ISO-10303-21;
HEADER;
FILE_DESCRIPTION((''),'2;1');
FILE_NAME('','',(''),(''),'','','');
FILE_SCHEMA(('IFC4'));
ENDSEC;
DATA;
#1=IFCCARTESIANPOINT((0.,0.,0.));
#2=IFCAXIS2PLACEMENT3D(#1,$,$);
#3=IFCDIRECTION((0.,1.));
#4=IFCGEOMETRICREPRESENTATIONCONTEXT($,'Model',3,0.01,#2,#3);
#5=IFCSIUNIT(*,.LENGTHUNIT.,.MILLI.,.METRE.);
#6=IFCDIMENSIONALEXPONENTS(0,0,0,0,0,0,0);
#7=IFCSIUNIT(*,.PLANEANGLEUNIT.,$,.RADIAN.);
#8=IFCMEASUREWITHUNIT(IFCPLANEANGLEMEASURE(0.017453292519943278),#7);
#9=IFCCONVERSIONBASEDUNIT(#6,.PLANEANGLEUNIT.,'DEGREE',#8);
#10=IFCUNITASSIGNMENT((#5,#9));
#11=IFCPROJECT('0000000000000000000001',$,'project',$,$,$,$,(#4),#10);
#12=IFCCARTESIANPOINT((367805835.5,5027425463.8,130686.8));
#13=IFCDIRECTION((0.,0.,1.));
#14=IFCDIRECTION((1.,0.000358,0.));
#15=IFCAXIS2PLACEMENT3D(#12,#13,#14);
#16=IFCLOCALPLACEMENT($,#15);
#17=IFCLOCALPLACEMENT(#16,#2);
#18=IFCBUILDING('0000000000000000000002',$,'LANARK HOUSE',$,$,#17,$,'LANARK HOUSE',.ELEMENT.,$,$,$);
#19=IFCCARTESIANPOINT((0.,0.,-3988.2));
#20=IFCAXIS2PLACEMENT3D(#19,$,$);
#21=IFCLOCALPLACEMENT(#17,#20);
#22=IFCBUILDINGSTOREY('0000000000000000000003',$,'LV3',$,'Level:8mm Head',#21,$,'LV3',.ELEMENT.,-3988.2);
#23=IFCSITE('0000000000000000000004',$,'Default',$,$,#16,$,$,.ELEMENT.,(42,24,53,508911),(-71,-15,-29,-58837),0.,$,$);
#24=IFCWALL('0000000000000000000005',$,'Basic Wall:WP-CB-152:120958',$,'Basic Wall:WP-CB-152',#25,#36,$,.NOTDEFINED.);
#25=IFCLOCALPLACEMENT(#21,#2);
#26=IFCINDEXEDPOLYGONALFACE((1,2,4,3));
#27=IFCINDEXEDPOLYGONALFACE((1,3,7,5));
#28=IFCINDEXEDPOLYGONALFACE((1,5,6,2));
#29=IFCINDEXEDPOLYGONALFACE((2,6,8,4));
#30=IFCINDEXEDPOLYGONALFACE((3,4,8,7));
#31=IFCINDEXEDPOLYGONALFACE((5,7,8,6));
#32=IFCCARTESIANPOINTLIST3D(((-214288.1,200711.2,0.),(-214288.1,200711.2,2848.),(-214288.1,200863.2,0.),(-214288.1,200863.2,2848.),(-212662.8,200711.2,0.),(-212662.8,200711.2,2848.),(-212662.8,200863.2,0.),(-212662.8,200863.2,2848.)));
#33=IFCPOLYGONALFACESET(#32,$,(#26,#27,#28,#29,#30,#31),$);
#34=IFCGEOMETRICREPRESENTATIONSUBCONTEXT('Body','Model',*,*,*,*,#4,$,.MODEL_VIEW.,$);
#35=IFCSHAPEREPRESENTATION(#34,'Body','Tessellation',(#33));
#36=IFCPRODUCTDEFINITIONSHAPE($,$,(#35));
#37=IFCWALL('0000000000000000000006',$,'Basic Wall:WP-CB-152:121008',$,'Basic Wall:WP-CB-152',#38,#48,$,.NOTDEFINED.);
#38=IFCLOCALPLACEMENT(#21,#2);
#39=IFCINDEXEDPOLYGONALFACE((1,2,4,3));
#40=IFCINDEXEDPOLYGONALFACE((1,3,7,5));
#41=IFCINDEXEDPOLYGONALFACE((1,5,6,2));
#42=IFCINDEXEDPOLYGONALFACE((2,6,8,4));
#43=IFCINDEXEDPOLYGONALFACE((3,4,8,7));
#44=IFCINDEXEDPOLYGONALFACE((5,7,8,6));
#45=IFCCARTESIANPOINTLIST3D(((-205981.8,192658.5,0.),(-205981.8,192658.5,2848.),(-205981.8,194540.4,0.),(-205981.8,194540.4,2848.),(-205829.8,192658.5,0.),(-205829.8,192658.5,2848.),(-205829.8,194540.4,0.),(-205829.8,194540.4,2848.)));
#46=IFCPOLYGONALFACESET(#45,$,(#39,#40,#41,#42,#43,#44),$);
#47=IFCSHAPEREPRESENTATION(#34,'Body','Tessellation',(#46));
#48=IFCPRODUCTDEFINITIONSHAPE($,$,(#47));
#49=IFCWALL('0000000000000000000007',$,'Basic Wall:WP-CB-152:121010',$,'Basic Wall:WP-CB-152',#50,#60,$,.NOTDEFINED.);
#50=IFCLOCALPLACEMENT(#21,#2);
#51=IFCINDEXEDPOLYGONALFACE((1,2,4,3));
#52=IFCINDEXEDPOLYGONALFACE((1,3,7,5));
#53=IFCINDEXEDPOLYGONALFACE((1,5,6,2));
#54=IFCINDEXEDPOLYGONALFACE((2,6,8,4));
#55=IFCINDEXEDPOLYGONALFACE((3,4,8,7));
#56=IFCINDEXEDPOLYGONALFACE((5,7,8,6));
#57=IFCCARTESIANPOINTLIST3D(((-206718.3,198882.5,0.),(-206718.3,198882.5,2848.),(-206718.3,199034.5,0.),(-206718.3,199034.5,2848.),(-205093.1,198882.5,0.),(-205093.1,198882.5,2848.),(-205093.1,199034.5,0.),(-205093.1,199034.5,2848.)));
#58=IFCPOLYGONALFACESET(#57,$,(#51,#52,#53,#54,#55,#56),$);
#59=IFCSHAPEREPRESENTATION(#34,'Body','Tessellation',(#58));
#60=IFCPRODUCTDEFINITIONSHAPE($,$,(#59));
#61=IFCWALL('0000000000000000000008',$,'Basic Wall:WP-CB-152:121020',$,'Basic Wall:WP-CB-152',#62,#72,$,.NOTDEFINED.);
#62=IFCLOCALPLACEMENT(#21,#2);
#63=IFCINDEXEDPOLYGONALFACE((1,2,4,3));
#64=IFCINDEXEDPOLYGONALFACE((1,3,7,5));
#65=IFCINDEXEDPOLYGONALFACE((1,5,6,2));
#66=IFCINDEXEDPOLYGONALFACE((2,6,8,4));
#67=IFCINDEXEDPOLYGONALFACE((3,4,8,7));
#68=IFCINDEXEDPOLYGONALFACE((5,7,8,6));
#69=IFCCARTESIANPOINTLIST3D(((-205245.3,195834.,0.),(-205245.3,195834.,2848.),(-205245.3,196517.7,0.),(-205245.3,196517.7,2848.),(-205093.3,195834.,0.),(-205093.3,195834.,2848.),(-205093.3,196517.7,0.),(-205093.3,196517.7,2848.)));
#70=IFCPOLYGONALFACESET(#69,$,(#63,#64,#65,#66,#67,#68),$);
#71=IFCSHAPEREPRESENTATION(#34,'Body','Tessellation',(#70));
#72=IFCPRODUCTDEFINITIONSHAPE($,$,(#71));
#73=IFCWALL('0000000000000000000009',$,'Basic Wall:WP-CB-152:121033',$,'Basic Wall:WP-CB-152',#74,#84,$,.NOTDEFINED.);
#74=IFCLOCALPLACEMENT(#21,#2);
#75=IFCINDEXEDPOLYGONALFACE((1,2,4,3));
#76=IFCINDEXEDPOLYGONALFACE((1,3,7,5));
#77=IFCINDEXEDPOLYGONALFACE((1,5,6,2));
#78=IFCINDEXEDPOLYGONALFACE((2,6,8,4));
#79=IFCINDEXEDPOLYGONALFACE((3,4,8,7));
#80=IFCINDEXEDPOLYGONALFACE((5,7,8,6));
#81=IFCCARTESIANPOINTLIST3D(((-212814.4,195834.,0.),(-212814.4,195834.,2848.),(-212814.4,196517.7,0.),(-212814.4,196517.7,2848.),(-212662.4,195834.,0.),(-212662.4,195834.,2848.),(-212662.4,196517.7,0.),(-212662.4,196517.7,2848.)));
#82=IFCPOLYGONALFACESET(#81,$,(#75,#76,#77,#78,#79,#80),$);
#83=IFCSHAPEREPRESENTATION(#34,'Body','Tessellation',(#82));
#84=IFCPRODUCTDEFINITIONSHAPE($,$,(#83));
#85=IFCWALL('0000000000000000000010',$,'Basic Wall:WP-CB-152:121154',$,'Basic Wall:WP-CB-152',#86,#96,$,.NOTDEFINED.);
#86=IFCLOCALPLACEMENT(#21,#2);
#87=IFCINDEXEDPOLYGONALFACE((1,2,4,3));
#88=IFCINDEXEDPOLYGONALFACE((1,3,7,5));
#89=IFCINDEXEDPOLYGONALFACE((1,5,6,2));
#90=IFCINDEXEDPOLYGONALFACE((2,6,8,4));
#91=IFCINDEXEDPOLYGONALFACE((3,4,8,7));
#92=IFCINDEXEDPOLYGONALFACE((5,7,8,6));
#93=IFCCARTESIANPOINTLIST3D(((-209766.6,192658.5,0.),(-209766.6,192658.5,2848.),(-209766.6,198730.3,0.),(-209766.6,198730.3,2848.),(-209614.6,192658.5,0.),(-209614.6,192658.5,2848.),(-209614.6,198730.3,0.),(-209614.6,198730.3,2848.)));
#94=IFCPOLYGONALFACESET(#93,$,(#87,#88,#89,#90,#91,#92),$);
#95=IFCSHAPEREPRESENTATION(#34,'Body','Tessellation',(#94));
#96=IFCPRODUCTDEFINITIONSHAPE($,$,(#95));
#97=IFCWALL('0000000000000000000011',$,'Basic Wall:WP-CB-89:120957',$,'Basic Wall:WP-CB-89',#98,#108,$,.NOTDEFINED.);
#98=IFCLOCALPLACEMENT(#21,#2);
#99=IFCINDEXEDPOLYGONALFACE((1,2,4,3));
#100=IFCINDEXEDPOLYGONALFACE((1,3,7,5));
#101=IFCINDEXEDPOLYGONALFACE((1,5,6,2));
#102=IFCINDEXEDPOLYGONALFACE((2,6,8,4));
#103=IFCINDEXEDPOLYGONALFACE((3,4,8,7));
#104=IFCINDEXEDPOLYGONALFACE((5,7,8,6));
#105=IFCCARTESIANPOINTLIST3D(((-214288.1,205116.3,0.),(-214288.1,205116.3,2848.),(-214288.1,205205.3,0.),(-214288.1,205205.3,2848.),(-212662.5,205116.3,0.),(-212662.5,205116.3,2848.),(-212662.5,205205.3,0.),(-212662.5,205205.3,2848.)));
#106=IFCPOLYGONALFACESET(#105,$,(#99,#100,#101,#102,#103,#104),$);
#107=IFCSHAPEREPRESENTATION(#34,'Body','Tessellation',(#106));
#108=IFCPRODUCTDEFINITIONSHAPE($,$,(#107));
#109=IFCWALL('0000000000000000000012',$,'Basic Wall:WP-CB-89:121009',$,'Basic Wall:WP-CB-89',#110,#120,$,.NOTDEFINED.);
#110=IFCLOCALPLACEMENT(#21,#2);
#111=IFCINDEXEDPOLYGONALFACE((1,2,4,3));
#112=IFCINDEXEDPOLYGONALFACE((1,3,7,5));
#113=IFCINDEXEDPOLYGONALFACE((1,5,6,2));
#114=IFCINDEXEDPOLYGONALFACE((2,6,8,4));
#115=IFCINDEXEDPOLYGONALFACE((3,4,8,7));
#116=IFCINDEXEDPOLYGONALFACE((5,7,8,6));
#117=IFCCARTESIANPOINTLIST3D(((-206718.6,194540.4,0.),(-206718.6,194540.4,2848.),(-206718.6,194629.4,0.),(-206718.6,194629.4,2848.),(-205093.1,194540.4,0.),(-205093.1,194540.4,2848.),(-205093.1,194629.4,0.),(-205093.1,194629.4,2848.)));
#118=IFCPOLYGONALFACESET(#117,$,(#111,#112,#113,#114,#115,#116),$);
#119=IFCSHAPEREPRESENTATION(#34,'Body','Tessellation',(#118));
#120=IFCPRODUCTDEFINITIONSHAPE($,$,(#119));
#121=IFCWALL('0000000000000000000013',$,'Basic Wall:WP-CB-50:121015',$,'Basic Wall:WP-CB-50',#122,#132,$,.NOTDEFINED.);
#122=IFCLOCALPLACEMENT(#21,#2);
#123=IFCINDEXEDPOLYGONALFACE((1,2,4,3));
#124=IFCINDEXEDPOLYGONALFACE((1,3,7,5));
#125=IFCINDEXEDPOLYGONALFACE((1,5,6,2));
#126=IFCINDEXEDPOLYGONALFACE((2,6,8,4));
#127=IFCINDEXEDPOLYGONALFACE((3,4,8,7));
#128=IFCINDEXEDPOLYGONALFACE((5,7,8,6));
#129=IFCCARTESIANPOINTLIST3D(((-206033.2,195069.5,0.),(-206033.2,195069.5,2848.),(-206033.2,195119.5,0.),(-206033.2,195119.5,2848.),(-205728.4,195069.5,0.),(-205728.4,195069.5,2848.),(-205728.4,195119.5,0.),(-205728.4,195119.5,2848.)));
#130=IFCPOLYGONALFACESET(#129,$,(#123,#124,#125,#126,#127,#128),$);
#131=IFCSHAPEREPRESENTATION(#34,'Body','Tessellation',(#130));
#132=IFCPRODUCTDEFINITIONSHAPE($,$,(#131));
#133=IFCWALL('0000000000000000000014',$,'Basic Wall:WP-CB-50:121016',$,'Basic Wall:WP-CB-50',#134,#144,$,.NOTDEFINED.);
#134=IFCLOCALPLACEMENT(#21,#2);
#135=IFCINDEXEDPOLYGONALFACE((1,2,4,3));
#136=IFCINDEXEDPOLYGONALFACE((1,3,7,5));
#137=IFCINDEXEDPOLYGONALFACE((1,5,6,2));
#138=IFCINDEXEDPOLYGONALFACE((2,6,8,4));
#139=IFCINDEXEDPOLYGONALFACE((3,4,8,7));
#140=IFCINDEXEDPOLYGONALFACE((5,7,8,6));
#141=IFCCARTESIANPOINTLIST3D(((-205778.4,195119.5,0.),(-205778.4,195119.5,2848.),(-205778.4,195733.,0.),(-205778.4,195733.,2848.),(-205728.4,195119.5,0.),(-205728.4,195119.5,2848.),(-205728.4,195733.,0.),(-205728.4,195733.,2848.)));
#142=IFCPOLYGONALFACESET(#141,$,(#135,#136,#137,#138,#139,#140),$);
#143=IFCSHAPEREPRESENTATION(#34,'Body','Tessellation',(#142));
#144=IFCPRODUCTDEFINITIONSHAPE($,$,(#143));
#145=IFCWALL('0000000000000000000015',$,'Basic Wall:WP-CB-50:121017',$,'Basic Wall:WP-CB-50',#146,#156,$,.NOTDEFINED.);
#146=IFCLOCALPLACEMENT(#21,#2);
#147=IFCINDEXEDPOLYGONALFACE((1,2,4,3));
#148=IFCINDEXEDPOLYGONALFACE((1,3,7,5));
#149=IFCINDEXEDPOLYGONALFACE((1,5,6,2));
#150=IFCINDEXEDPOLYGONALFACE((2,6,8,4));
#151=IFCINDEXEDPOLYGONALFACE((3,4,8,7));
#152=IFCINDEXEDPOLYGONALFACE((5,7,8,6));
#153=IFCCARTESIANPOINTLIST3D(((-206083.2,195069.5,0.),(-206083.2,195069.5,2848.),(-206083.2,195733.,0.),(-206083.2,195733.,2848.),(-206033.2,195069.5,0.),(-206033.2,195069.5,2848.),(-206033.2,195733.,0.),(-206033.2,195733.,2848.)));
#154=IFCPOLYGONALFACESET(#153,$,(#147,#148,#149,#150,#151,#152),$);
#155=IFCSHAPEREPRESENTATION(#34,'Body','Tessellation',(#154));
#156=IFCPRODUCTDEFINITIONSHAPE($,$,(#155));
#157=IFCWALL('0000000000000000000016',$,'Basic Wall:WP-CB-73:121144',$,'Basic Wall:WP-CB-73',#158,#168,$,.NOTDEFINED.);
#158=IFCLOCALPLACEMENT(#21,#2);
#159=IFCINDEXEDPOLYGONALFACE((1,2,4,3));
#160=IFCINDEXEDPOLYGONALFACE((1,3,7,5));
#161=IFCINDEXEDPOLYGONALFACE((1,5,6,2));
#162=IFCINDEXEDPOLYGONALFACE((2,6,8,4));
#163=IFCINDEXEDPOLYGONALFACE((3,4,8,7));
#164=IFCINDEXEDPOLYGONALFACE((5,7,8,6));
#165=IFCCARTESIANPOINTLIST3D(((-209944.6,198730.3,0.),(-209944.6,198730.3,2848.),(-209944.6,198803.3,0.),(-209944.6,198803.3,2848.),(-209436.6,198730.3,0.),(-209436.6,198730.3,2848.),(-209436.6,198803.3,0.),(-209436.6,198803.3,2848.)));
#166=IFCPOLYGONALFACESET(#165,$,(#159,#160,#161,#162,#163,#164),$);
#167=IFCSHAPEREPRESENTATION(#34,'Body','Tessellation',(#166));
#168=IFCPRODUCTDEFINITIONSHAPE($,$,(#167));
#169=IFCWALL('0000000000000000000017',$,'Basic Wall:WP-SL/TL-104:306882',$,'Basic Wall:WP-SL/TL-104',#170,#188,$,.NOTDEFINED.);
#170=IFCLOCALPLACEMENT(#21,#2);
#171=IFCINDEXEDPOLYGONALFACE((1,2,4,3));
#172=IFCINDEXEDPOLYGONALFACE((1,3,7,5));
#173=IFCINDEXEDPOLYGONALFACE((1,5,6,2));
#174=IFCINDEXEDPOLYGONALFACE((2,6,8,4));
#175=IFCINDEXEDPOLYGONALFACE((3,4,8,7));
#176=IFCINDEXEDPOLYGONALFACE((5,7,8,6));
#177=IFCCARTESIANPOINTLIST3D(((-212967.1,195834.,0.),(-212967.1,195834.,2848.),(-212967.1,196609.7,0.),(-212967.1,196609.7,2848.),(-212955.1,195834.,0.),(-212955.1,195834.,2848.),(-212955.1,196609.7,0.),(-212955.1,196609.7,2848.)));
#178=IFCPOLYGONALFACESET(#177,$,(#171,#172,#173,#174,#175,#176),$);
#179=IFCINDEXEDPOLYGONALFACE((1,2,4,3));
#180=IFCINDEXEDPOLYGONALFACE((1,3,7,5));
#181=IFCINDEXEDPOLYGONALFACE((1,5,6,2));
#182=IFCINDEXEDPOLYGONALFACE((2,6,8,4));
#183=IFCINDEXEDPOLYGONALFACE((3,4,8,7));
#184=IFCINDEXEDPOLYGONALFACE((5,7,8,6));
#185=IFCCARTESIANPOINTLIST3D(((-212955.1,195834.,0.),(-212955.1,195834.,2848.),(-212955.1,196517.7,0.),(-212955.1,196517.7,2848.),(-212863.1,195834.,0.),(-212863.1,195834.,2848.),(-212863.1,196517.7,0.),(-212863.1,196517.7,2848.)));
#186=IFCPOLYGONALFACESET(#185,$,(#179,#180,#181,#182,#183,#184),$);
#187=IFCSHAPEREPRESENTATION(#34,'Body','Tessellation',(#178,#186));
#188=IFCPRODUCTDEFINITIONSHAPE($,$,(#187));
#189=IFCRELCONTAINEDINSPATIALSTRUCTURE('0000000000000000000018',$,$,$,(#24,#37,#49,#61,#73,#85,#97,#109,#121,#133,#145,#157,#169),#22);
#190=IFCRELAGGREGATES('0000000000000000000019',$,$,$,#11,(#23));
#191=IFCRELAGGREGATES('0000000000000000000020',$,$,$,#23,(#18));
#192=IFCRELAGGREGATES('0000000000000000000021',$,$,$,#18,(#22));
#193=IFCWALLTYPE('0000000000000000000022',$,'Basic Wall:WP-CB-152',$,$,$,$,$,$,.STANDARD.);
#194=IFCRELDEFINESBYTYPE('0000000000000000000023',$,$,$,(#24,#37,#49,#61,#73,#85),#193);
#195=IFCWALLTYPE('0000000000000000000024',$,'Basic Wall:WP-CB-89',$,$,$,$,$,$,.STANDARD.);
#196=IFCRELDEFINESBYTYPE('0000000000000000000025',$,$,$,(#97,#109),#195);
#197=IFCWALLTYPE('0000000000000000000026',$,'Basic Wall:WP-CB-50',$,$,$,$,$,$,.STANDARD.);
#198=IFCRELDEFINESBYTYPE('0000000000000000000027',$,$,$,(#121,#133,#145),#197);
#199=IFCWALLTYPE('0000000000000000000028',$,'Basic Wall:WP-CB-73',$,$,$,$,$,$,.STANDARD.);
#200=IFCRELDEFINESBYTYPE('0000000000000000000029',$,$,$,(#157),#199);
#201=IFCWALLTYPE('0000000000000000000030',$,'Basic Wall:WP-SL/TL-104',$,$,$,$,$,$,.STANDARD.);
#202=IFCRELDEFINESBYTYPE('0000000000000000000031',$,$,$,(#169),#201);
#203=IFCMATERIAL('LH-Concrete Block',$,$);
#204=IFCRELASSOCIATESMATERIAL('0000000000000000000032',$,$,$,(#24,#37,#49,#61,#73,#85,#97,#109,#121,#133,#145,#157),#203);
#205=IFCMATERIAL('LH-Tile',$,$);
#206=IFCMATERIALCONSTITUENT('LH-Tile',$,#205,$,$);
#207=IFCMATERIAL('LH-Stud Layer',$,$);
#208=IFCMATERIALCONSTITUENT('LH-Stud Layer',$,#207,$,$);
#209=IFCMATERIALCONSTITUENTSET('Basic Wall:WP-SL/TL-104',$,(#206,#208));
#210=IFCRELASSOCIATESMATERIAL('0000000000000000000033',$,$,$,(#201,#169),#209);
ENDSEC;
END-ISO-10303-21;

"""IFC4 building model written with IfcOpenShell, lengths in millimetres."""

from ifc_helpers import new_model, entity, si_unit, converted_unit, direction, frame, origin, place, context, subcontext, project, spatial, indexed_curve, outline, extrude, material, constituent, constituent_set, type_object, element, save


model = new_model("IFC4")

# Units and contexts
model_context = context("Model", 3, precision=0.01, world=origin(), true_north=direction((0.0, 1.0)))
body_context = subcontext(model_context, "Body", "Model", "MODEL_VIEW")
ifc_project = project(units=[si_unit("LENGTHUNIT", "METRE", prefix="MILLI"), converted_unit("PLANEANGLEUNIT", "DEGREE", entity("IfcPlaneAngleMeasure", 0.017453292519943278), si_unit("PLANEANGLEUNIT", "RADIAN"), dimensions=[0, 0, 0, 0, 0, 0, 0])], contexts=[model_context])

# Site, building, storey
site_placement = place(None, frame((367805835.5, 5027425463.8, 130686.8), z_axis=(0.0, 0.0, 1.0), x_axis=(1.0, 0.000358, 0.0)))
site = spatial("IfcSite", under=ifc_project, at=site_placement, Name="Default", CompositionType="ELEMENT", RefLatitude=(42, 24, 53, 508911), RefLongitude=(-71, -15, -29, -58837), RefElevation=0.0)
building_placement = place(site_placement, origin())
building = spatial("IfcBuilding", under=site, at=building_placement, Name="LANARK HOUSE", LongName="LANARK HOUSE", CompositionType="ELEMENT")
storey_placement = place(building_placement, frame((0.0, 0.0, -3988.2)))
storey = spatial("IfcBuildingStorey", under=building, at=storey_placement, Name="LV3", ObjectType="Level:8mm Head", LongName="LV3", CompositionType="ELEMENT", Elevation=-3988.2)

# Walls
ifc_material_1 = material(Name="LH-Concrete Block")
wall_type_1 = type_object("IfcWallType", Name="Basic Wall:WP-CB-152", PredefinedType="STANDARD")
wall_1_placement = place(storey_placement, frame((-212662.8, 200787.2, 0.0), z_axis=(0.0, 0.0, 1.0), x_axis=(-1.0, 0.0, 0.0)))
element("IfcWall", 1, at=wall_1_placement, inside=storey, type_object=wall_type_1, material=ifc_material_1, Name="Basic Wall:WP-CB-152:120958", ObjectType="Basic Wall:WP-CB-152", PredefinedType="NOTDEFINED", context=body_context, shape_type="SweptSolid", body=[
    extrude(outline(indexed_curve([(1625.3, 76.0), (0.0, 76.0), (0.0, -76.0), (1625.3, -76.0), (1625.3, 76.0)], self_intersect=False)), origin(), (0.0, 0.0, 1.0), 2848.0),
])
wall_2_placement = place(storey_placement, frame((-205905.8, 194540.4, 0.0), z_axis=(0.0, 0.0, 1.0), x_axis=(0.0, -1.0, 0.0)))
element("IfcWall", 2, at=wall_2_placement, inside=storey, type_object=wall_type_1, material=ifc_material_1, Name="Basic Wall:WP-CB-152:121008", ObjectType="Basic Wall:WP-CB-152", PredefinedType="NOTDEFINED", context=body_context, shape_type="SweptSolid", body=[
    extrude(outline(indexed_curve([(1881.9, 76.0), (0.0, 76.0), (0.0, -76.0), (1881.9, -76.0), (1881.9, 76.0)], self_intersect=False)), origin(), (0.0, 0.0, 1.0), 2848.0),
])
wall_3_placement = place(storey_placement, frame((-206718.3, 198958.5, 0.0)))
element("IfcWall", 3, at=wall_3_placement, inside=storey, type_object=wall_type_1, material=ifc_material_1, Name="Basic Wall:WP-CB-152:121010", ObjectType="Basic Wall:WP-CB-152", PredefinedType="NOTDEFINED", context=body_context, shape_type="SweptSolid", body=[
    extrude(outline(indexed_curve([(1625.3, 76.0), (0.0, 76.0), (0.0, -76.0), (1625.3, -76.0), (1625.3, 76.0)], self_intersect=False)), origin(), (0.0, 0.0, 1.0), 2848.0),
])
for number, where, z_axis, x_axis, name in (
    (4, (-205169.3, 196517.7, 0.0), (0.0, 0.0, 1.0), (0.0, -1.0, 0.0), "Basic Wall:WP-CB-152:121020"),
    (5, (-212738.4, 196517.7, 0.0), (0.0, 0.0, 1.0), (0.0, -1.0, 0.0), "Basic Wall:WP-CB-152:121033"),
):
    element("IfcWall", number, at=place(storey_placement, frame(where, z_axis=z_axis, x_axis=x_axis)), inside=storey, type_object=wall_type_1, material=ifc_material_1, Name=name, ObjectType="Basic Wall:WP-CB-152", PredefinedType="NOTDEFINED", context=body_context, shape_type="SweptSolid", body=[
        extrude(outline(indexed_curve([(683.7, 76.0), (0.0, 76.0), (0.0, -76.0), (683.7, -76.0), (683.7, 76.0)], self_intersect=False)), origin(), (0.0, 0.0, 1.0), 2848.0),
    ])
wall_4_placement = place(storey_placement, frame((-209690.6, 192658.5, 0.0), z_axis=(0.0, 0.0, 1.0), x_axis=(0.0, 1.0, 0.0)))
element("IfcWall", 6, at=wall_4_placement, inside=storey, type_object=wall_type_1, material=ifc_material_1, Name="Basic Wall:WP-CB-152:121154", ObjectType="Basic Wall:WP-CB-152", PredefinedType="NOTDEFINED", context=body_context, shape_type="SweptSolid", body=[
    extrude(outline(indexed_curve([(6071.8, 76.0), (0.0, 76.0), (0.0, -76.0), (6071.8, -76.0), (6071.8, 76.0)], self_intersect=False)), origin(), (0.0, 0.0, 1.0), 2848.0),
])
wall_type_2 = type_object("IfcWallType", Name="Basic Wall:WP-CB-89", PredefinedType="STANDARD")
wall_5_placement = place(storey_placement, frame((-212662.5, 205160.8, 0.0), z_axis=(0.0, 0.0, 1.0), x_axis=(-1.0, 0.0, 0.0)))
element("IfcWall", 7, at=wall_5_placement, inside=storey, type_object=wall_type_2, material=ifc_material_1, Name="Basic Wall:WP-CB-89:120957", ObjectType="Basic Wall:WP-CB-89", PredefinedType="NOTDEFINED", context=body_context, shape_type="SweptSolid", body=[
    extrude(outline(indexed_curve([(1625.6, 44.5), (0.0, 44.5), (0.0, -44.5), (1625.6, -44.5), (1625.6, 44.5)], self_intersect=False)), origin(), (0.0, 0.0, 1.0), 2848.0),
])
wall_6_placement = place(storey_placement, frame((-206718.6, 194584.9, 0.0)))
element("IfcWall", 8, at=wall_6_placement, inside=storey, type_object=wall_type_2, material=ifc_material_1, Name="Basic Wall:WP-CB-89:121009", ObjectType="Basic Wall:WP-CB-89", PredefinedType="NOTDEFINED", context=body_context, shape_type="SweptSolid", body=[
    extrude(outline(indexed_curve([(1625.6, 44.5), (0.0, 44.5), (0.0, -44.5), (1625.6, -44.5), (1625.6, 44.5)], self_intersect=False)), origin(), (0.0, 0.0, 1.0), 2848.0),
])
wall_type_3 = type_object("IfcWallType", Name="Basic Wall:WP-CB-50", PredefinedType="STANDARD")
wall_7_placement = place(storey_placement, frame((-205728.4, 195094.5, 0.0), z_axis=(0.0, 0.0, 1.0), x_axis=(-1.0, 0.0, 0.0)))
element("IfcWall", 9, at=wall_7_placement, inside=storey, type_object=wall_type_3, material=ifc_material_1, Name="Basic Wall:WP-CB-50:121015", ObjectType="Basic Wall:WP-CB-50", PredefinedType="NOTDEFINED", context=body_context, shape_type="SweptSolid", body=[
    extrude(outline(indexed_curve([(304.8, 25.0), (0.0, 25.0), (0.0, -25.0), (304.8, -25.0), (304.8, 25.0)], self_intersect=False)), origin(), (0.0, 0.0, 1.0), 2848.0),
])
wall_8_placement = place(storey_placement, frame((-205753.4, 195733.0, 0.0), z_axis=(0.0, 0.0, 1.0), x_axis=(0.0, -1.0, 0.0)))
element("IfcWall", 10, at=wall_8_placement, inside=storey, type_object=wall_type_3, material=ifc_material_1, Name="Basic Wall:WP-CB-50:121016", ObjectType="Basic Wall:WP-CB-50", PredefinedType="NOTDEFINED", context=body_context, shape_type="SweptSolid", body=[
    extrude(outline(indexed_curve([(613.5, 25.0), (0.0, 25.0), (0.0, -25.0), (613.5, -25.0), (613.5, 25.0)], self_intersect=False)), origin(), (0.0, 0.0, 1.0), 2848.0),
])
wall_9_placement = place(storey_placement, frame((-206058.2, 195733.0, 0.0), z_axis=(0.0, 0.0, 1.0), x_axis=(0.0, -1.0, 0.0)))
element("IfcWall", 11, at=wall_9_placement, inside=storey, type_object=wall_type_3, material=ifc_material_1, Name="Basic Wall:WP-CB-50:121017", ObjectType="Basic Wall:WP-CB-50", PredefinedType="NOTDEFINED", context=body_context, shape_type="SweptSolid", body=[
    extrude(outline(indexed_curve([(663.5, 25.0), (0.0, 25.0), (0.0, -25.0), (663.5, -25.0), (663.5, 25.0)], self_intersect=False)), origin(), (0.0, 0.0, 1.0), 2848.0),
])
wall_type_4 = type_object("IfcWallType", Name="Basic Wall:WP-CB-73", PredefinedType="STANDARD")
wall_10_placement = place(storey_placement, frame((-209436.6, 198766.8, 0.0), z_axis=(0.0, 0.0, 1.0), x_axis=(-1.0, 0.0, 0.0)))
element("IfcWall", 12, at=wall_10_placement, inside=storey, type_object=wall_type_4, material=ifc_material_1, Name="Basic Wall:WP-CB-73:121144", ObjectType="Basic Wall:WP-CB-73", PredefinedType="NOTDEFINED", context=body_context, shape_type="SweptSolid", body=[
    extrude(outline(indexed_curve([(508.0, 36.5), (0.0, 36.5), (0.0, -36.5), (508.0, -36.5), (508.0, 36.5)], self_intersect=False)), origin(), (0.0, 0.0, 1.0), 2848.0),
])
ifc_material_2 = material(Name="LH-Tile")
ifc_constituent_1 = constituent(ifc_material_2, Name="LH-Tile")
ifc_material_3 = material(Name="LH-Stud Layer")
ifc_constituent_2 = constituent(ifc_material_3, Name="LH-Stud Layer")
ifc_constituent_set_1 = constituent_set(constituents=[ifc_constituent_1, ifc_constituent_2], Name="Basic Wall:WP-SL/TL-104")
wall_type_5 = type_object("IfcWallType", Name="Basic Wall:WP-SL/TL-104", PredefinedType="STANDARD", material=ifc_constituent_set_1)
wall_11_placement = place(storey_placement, frame((-212915.1, 195834.0, 0.0), z_axis=(0.0, 0.0, 1.0), x_axis=(0.0, 1.0, 0.0)))
element("IfcWall", 13, at=wall_11_placement, inside=storey, type_object=wall_type_5, material=ifc_constituent_set_1, Name="Basic Wall:WP-SL/TL-104:306882", ObjectType="Basic Wall:WP-SL/TL-104", PredefinedType="NOTDEFINED", context=body_context, shape_type="SweptSolid", body=[
    extrude(outline(indexed_curve([(-6.0, -387.8), (6.0, -387.8), (6.0, 387.8), (-6.0, 387.8), (-6.0, -387.8)], self_intersect=False)), frame((387.8, 46.0, 0.0), z_axis=(0.0, 0.0, 1.0), x_axis=(0.0, -1.0, 0.0)), (0.0, 0.0, 1.0), 2848.0),
    extrude(outline(indexed_curve([(-46.0, -341.8), (46.0, -341.8), (46.0, 341.8), (-46.0, 341.8), (-46.0, -341.8)], self_intersect=False)), frame((341.8, -6.0, 0.0), z_axis=(0.0, 0.0, 1.0), x_axis=(0.0, 1.0, 0.0)), (0.0, 0.0, 1.0), 2848.0),
])

save(model, "model.ifc")
